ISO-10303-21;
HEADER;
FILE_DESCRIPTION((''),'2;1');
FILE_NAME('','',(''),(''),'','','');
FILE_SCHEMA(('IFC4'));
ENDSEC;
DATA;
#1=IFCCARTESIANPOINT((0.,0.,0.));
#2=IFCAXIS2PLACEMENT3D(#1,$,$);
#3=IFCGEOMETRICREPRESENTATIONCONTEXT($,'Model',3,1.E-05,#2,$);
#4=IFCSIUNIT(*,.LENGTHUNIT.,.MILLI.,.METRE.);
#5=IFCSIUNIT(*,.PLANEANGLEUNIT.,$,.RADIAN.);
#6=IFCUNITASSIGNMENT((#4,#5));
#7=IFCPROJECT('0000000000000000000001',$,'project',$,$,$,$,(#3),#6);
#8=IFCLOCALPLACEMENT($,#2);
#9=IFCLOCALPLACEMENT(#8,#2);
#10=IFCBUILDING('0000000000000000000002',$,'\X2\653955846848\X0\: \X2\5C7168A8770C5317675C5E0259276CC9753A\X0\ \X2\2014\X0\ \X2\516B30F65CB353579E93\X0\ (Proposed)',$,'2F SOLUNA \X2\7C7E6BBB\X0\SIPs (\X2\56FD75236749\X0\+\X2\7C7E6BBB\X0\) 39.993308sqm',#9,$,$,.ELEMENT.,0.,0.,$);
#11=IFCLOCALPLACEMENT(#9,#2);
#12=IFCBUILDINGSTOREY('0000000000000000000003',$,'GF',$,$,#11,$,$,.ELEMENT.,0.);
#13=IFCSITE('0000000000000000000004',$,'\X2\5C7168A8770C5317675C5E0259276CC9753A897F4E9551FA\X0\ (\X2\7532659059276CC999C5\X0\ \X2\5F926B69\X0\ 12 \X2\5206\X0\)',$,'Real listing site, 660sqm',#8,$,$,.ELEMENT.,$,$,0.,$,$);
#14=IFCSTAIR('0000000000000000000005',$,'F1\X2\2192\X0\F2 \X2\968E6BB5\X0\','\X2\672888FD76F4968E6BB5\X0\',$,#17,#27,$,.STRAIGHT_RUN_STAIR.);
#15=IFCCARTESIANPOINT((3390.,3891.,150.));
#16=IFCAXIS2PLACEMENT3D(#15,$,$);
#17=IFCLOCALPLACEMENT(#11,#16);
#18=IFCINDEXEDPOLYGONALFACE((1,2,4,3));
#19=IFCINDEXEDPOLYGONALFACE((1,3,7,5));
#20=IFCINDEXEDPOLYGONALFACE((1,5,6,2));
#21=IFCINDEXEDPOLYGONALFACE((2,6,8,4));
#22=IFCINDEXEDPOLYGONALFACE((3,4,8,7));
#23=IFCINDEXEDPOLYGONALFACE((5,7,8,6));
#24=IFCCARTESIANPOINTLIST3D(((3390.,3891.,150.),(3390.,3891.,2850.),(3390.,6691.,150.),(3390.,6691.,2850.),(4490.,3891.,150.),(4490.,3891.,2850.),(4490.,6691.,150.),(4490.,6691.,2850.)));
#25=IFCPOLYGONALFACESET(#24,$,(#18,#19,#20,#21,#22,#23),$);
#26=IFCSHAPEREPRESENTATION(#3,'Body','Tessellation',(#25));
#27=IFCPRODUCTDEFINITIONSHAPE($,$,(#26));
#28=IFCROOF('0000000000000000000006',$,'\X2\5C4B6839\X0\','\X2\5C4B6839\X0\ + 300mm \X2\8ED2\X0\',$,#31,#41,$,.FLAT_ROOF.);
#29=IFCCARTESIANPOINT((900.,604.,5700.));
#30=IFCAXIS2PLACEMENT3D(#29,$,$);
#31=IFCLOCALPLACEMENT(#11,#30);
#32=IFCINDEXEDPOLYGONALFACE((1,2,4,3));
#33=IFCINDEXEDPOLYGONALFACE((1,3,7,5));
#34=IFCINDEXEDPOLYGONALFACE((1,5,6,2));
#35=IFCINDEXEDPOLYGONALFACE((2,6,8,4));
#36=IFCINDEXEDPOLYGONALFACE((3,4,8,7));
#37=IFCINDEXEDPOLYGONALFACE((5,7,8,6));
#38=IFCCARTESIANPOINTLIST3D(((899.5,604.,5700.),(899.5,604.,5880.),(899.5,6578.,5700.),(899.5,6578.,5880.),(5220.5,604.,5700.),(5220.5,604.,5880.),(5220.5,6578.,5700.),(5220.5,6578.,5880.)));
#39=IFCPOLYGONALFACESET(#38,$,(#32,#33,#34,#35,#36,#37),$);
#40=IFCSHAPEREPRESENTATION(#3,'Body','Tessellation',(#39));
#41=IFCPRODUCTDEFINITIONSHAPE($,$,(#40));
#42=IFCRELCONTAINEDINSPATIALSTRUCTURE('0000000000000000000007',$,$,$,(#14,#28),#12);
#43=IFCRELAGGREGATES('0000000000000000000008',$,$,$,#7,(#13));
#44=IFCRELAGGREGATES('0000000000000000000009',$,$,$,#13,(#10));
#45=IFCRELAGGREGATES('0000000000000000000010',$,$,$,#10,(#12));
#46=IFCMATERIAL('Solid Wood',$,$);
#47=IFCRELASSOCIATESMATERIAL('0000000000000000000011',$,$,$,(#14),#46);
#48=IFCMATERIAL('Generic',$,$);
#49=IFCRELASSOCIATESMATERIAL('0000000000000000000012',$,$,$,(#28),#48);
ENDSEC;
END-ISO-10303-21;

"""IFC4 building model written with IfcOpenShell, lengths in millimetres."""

from ifc_helpers import new_model, si_unit, frame, frame_2d, origin, place, context, project, spatial, rectangle, extrude, material, element, save


model = new_model("IFC4")

# Units and contexts
model_context = context("Model", 3, precision=1e-05, world=origin())
ifc_project = project(units=[si_unit("LENGTHUNIT", "METRE", prefix="MILLI"), si_unit("PLANEANGLEUNIT", "RADIAN")], contexts=[model_context])

# Site, building, storey
site_placement = place(None, origin())
site = spatial("IfcSite", under=ifc_project, at=site_placement, Name="山梨県北杜市大泉町西井出 (甲斐大泉駅 徒歩 12 分)", ObjectType="Real listing site, 660sqm", CompositionType="ELEMENT", RefElevation=0.0)
building_placement = place(site_placement, origin())
building = spatial("IfcBuilding", under=site, at=building_placement, Name="改善案: 山梨県北杜市大泉町 — 八ヶ岳南麓 (Proposed)", ObjectType="2F SOLUNA 籾殻SIPs (国産杉+籾殻) 39.993308sqm", CompositionType="ELEMENT", ElevationOfRefHeight=0.0, ElevationOfTerrain=0.0)
storey_placement = place(building_placement, origin())
storey = spatial("IfcBuildingStorey", under=building, at=storey_placement, Name="GF", CompositionType="ELEMENT", Elevation=0.0)

# Shared definitions
ifc_material_1 = material(Name="Generic")

# Shared definitions
ifc_material_2 = material(Name="Solid Wood")

# Stair
stair_placement = place(storey_placement, frame((3390.0, 3891.0, 150.0)))
element("IfcStair", 1, at=stair_placement, inside=storey, material=ifc_material_2, Name="F1→F2 階段", Description="木製直階段", PredefinedType="STRAIGHT_RUN_STAIR", context=model_context, shape_type="SweptSolid", body=[
    extrude(rectangle(XDim=1100.0, YDim=2800.0, at=frame_2d((550.0, 1400.0))), frame((3390.0, 3891.0, 150.0)), (0.0, 0.0, 1.0), 2700.0),
])

# Roof
roof_placement = place(storey_placement, frame((900.0, 604.0, 5700.0)))
element("IfcRoof", 2, at=roof_placement, inside=storey, material=ifc_material_1, Name="屋根", Description="屋根 + 300mm 軒", PredefinedType="FLAT_ROOF", context=model_context, shape_type="SweptSolid", body=[
    extrude(rectangle(XDim=4321.0, YDim=5974.0, at=frame_2d((2160.0, 2987.0))), frame((900.0, 604.0, 5700.0)), (0.0, 0.0, 1.0), 180.0),
])

save(model, "model.ifc")
